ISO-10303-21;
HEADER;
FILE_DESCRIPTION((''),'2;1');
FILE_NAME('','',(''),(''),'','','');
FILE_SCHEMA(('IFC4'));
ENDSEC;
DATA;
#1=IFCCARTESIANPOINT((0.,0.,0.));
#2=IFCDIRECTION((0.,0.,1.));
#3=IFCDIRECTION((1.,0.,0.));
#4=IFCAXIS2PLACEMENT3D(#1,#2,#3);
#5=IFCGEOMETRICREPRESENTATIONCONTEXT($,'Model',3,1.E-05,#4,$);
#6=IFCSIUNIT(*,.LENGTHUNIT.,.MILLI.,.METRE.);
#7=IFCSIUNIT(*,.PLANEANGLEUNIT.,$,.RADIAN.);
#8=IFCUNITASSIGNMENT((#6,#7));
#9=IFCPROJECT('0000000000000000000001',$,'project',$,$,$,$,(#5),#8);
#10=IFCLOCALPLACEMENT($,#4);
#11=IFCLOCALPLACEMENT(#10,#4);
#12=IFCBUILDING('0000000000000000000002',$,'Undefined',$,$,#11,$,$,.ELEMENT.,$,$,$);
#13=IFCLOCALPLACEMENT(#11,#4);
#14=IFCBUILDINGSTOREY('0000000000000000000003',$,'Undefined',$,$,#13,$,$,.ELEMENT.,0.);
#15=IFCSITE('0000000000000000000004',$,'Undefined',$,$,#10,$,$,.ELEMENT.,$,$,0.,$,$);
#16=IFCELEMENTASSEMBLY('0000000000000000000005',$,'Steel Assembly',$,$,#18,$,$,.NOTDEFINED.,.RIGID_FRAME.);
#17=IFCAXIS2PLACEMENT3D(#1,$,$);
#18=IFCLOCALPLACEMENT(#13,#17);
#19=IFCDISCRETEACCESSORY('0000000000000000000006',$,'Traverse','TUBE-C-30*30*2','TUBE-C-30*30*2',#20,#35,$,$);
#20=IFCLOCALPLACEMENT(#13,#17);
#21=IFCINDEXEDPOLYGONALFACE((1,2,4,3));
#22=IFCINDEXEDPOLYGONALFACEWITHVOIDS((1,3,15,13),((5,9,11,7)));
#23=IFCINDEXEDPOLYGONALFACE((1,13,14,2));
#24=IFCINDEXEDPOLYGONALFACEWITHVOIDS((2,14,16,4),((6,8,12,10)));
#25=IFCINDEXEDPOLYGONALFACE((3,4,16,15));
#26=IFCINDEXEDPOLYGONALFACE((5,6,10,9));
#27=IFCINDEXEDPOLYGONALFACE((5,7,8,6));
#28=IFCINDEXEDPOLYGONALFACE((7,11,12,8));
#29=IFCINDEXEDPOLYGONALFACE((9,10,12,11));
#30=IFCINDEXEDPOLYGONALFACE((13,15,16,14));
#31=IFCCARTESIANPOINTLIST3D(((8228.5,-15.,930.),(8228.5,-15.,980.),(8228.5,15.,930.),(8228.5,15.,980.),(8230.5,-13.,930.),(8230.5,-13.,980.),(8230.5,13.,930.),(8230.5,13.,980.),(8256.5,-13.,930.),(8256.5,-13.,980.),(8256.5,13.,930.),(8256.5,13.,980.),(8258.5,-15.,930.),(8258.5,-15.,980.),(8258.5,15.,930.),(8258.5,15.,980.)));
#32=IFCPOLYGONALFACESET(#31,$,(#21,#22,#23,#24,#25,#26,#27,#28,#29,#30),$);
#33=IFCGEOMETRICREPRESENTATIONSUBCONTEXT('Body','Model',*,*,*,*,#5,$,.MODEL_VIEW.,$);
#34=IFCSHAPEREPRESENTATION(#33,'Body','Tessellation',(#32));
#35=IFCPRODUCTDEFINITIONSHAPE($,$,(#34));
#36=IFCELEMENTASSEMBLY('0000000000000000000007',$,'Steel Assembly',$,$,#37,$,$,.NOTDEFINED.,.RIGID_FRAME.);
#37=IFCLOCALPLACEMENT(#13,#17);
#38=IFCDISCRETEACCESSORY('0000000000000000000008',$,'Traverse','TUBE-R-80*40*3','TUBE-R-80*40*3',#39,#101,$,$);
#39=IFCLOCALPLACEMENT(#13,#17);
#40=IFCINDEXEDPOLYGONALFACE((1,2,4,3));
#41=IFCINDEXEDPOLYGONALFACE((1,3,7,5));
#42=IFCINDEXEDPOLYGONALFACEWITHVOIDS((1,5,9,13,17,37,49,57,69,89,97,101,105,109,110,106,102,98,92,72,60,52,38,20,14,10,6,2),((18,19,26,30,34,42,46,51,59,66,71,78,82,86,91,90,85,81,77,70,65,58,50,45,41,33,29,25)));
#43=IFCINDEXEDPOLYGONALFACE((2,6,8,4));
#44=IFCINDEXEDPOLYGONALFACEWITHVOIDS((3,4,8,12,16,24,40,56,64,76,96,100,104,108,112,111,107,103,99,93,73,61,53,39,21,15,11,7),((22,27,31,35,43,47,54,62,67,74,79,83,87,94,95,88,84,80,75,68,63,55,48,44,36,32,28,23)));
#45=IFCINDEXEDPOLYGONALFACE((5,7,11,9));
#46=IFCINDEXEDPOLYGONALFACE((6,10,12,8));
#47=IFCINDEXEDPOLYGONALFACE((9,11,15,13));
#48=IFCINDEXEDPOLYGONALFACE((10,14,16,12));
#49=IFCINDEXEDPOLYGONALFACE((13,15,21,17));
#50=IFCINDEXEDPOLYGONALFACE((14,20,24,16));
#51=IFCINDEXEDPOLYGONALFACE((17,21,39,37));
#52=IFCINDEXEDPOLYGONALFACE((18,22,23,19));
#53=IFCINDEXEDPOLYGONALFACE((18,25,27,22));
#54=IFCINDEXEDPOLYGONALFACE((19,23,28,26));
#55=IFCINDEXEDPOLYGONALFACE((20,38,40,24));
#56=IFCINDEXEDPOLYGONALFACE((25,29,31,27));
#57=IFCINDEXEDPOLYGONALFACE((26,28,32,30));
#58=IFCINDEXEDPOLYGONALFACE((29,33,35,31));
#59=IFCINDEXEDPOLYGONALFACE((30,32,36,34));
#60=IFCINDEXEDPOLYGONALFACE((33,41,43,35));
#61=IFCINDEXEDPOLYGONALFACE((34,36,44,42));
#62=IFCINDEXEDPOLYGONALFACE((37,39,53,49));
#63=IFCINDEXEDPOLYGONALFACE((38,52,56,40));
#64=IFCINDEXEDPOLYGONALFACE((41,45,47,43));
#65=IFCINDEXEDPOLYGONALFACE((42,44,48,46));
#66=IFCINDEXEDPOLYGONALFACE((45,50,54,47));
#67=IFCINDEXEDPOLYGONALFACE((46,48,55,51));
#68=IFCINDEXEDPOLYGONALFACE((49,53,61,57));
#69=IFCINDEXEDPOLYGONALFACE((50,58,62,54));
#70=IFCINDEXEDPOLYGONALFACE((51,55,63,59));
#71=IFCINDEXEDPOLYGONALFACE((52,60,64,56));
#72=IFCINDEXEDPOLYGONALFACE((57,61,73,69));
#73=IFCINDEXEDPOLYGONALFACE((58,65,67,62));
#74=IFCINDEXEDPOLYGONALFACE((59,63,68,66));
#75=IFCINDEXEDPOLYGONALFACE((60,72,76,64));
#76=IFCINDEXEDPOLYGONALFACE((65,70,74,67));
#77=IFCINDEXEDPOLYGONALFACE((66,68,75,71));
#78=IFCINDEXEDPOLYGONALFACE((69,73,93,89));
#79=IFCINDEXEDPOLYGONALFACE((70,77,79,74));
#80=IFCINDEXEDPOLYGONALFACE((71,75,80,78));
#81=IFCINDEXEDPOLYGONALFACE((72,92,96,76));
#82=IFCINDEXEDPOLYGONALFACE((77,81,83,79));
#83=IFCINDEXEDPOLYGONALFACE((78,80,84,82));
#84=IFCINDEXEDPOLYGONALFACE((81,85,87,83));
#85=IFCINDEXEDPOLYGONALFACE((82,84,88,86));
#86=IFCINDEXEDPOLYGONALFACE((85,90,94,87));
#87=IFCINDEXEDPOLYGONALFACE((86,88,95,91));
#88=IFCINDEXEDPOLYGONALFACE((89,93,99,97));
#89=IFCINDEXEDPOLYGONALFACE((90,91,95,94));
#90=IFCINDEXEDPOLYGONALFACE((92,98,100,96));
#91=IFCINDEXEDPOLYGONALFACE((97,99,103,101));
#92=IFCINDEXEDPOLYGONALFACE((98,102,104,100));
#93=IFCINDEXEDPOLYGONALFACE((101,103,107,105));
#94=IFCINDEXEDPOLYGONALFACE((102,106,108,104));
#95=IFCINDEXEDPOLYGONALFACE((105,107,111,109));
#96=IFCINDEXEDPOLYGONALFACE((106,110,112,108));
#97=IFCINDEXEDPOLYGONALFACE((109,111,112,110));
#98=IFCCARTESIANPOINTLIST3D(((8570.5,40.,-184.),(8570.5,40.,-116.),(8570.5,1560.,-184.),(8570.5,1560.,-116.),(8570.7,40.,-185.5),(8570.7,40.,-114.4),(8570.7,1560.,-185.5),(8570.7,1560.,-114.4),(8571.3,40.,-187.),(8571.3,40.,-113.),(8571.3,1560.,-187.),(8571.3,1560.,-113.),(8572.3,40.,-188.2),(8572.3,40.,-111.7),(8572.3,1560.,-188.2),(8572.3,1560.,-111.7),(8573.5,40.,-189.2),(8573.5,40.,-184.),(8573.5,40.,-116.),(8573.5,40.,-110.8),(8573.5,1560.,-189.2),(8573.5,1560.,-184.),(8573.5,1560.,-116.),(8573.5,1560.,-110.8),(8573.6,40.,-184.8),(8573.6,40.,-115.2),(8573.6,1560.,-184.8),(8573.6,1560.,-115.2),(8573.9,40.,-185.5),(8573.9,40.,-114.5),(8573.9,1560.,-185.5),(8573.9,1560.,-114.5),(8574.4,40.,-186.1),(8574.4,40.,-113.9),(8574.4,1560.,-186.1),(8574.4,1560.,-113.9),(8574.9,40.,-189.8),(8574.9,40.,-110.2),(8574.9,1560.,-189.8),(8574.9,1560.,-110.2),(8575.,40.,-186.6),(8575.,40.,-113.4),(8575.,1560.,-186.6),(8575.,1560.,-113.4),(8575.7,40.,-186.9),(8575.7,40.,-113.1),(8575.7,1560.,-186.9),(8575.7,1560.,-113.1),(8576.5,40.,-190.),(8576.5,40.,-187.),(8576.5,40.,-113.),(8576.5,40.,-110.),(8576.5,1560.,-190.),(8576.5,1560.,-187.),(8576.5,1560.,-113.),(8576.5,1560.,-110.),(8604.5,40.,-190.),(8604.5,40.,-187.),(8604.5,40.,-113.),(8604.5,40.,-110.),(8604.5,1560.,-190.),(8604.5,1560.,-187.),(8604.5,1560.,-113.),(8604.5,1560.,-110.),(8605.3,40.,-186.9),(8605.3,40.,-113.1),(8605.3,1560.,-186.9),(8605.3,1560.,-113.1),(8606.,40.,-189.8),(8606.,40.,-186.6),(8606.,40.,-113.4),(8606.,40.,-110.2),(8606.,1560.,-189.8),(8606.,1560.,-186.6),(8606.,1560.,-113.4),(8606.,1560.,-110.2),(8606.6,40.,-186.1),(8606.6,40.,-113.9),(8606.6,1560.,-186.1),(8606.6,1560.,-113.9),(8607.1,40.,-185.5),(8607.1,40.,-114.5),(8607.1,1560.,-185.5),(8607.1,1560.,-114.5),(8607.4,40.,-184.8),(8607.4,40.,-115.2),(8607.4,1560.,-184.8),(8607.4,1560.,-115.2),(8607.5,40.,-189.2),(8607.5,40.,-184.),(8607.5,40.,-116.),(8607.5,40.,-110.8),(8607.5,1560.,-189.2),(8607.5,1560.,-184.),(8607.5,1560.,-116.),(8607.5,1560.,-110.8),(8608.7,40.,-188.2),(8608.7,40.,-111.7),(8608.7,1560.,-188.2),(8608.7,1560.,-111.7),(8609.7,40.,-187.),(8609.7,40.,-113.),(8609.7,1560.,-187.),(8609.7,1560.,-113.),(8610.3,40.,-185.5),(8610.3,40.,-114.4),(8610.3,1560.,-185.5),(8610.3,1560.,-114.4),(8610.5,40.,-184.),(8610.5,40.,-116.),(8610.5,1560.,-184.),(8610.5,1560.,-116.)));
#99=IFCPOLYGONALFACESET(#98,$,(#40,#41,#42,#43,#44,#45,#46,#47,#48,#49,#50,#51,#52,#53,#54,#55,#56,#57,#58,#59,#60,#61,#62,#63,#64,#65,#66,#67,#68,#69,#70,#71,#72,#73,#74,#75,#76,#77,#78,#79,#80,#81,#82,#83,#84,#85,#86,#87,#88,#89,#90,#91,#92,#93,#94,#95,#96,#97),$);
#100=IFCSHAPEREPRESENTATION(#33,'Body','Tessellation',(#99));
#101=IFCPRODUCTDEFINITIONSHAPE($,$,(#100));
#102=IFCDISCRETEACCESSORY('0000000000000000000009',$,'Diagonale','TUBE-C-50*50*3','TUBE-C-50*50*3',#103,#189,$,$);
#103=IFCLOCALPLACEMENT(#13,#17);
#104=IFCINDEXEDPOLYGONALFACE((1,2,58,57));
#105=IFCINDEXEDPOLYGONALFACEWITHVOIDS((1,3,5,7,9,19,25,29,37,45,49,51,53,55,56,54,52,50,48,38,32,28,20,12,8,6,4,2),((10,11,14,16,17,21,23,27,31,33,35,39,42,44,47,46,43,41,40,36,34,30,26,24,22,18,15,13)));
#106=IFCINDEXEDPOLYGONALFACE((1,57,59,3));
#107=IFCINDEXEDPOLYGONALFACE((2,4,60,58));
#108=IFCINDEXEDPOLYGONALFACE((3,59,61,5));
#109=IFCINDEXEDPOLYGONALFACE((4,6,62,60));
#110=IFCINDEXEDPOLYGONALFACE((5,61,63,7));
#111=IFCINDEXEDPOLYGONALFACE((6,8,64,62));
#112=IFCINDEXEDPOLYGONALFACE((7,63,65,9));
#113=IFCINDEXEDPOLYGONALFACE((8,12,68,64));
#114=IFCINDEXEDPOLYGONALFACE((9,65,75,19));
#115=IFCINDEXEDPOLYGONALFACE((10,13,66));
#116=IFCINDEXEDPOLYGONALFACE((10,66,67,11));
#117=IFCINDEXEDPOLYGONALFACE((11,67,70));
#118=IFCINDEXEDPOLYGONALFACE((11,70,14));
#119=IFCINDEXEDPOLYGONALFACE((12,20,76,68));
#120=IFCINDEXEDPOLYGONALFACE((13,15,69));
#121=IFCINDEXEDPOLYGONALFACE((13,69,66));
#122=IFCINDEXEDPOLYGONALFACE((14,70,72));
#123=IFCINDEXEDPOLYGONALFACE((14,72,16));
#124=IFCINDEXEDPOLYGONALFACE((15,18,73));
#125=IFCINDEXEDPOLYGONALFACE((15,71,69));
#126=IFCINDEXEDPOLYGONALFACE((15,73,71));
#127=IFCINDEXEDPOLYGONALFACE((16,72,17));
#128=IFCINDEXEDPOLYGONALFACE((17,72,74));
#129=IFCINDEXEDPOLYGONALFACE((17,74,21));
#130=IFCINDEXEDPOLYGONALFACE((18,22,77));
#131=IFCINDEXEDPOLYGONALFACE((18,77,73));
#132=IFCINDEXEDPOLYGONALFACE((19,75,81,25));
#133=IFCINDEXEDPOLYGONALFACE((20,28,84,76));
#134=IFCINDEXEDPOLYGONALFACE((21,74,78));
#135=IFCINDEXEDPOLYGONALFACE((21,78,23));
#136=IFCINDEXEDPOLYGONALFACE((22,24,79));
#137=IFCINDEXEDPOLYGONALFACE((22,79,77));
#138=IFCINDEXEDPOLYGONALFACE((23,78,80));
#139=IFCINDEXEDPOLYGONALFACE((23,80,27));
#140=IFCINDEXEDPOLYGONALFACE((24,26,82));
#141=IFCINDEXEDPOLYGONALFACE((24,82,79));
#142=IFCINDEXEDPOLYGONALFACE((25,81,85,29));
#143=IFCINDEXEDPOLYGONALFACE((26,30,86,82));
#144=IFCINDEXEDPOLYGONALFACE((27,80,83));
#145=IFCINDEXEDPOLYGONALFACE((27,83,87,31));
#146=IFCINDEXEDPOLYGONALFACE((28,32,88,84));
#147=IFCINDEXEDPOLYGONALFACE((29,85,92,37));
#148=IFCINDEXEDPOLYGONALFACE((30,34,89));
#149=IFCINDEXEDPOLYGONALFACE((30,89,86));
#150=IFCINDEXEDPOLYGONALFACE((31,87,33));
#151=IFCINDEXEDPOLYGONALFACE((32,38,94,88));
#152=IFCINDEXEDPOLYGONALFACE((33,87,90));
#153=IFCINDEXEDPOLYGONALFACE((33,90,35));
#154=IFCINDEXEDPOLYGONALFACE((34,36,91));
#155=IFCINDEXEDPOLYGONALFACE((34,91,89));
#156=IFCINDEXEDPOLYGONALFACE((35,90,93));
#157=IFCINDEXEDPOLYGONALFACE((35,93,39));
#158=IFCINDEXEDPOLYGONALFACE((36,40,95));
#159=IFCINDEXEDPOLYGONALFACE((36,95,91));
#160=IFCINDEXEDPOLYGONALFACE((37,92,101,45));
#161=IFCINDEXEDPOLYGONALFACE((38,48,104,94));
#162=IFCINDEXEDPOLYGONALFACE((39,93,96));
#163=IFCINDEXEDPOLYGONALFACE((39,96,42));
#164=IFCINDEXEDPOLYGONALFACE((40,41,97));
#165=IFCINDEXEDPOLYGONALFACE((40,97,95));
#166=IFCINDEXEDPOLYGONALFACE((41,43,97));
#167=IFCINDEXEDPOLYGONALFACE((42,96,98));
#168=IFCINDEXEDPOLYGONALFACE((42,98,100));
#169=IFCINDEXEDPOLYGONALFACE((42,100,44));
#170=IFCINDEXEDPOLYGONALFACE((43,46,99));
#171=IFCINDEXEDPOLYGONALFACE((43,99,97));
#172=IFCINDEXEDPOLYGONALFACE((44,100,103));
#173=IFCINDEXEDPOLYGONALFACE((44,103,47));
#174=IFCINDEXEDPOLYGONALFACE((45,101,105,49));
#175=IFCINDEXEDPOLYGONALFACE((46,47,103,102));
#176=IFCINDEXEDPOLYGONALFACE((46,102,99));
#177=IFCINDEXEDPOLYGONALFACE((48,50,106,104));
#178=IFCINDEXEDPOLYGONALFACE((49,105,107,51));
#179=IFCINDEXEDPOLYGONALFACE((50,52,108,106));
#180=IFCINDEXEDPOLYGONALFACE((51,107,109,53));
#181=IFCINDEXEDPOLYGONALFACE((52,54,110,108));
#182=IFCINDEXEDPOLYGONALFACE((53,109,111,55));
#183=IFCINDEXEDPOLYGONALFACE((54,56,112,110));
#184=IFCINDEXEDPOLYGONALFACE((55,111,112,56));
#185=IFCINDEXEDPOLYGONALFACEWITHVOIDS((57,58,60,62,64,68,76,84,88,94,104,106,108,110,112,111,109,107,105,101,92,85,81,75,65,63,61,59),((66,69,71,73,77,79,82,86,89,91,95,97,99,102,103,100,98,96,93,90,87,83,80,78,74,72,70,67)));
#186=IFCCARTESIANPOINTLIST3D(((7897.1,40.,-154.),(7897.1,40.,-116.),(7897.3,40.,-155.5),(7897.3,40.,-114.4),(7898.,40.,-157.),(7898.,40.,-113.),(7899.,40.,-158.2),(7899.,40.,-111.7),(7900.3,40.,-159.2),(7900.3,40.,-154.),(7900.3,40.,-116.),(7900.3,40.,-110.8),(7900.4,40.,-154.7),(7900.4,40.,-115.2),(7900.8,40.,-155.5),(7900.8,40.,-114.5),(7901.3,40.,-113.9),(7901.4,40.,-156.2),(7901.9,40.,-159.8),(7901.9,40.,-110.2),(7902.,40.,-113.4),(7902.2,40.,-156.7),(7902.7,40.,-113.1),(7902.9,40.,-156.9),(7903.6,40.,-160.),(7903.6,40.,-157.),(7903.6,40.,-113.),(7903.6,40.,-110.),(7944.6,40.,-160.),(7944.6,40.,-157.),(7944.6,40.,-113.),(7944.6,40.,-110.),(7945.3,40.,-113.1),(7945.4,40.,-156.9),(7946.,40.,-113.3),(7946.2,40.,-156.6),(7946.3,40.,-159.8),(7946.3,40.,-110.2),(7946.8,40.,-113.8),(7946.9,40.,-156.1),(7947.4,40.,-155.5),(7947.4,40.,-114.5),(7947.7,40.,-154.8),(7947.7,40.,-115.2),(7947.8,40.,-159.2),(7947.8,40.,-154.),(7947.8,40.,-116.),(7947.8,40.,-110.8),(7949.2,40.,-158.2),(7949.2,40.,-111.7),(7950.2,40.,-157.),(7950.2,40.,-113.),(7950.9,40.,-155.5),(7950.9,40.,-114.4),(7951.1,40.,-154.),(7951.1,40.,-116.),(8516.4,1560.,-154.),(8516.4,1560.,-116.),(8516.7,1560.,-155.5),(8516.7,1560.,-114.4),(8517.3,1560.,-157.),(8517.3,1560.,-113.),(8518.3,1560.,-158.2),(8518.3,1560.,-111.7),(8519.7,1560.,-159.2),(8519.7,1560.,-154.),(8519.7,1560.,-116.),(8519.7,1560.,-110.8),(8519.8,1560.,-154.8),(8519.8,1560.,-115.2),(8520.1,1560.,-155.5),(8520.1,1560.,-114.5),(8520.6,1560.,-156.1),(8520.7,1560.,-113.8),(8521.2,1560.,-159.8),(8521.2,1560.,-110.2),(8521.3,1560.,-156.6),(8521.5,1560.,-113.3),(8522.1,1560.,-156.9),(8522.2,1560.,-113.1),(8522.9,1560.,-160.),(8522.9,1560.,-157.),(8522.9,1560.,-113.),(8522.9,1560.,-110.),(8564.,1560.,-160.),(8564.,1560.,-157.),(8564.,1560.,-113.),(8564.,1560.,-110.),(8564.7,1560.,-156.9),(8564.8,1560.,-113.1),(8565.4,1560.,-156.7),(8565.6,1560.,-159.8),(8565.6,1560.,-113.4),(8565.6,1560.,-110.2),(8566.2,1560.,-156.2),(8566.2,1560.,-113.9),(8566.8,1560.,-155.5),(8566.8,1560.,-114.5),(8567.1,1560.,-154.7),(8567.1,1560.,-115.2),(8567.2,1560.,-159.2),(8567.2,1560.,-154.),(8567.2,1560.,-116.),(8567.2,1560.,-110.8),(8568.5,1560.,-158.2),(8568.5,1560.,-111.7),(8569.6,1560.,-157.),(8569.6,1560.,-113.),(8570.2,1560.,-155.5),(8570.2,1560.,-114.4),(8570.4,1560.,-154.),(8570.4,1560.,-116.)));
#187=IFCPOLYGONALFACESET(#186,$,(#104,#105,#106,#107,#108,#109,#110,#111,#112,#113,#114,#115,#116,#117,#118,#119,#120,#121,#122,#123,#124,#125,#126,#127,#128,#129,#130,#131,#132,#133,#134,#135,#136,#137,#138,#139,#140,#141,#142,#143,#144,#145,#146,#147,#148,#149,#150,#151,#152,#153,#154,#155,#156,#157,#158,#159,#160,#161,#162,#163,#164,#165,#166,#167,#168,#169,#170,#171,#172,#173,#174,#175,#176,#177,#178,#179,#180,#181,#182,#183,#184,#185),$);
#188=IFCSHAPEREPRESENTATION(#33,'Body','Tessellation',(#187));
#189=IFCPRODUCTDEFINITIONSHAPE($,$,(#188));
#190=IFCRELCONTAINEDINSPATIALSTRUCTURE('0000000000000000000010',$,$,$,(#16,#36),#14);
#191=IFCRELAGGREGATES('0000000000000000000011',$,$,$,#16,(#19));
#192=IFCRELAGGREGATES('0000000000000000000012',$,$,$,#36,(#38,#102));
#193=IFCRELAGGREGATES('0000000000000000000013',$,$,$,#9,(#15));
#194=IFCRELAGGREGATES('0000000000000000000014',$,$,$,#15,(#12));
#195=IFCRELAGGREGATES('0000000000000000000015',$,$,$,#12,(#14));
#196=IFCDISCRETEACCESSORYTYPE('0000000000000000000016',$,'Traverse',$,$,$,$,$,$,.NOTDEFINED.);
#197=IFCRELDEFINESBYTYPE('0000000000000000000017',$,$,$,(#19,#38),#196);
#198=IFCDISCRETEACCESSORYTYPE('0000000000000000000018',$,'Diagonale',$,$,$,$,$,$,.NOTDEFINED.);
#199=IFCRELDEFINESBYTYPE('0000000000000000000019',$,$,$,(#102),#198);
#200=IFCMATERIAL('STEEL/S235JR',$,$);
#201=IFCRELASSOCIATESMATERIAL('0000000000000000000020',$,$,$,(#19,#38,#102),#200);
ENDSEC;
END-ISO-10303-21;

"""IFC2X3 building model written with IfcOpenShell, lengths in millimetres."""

from ifc_helpers import new_model, si_unit, frame, origin_with_axes, origin_2d_with_axis, place, context, subcontext, project, spatial, hollow_rectangle, extrude, clip, halfspace, material, type_object, element, aggregate, save


model = new_model("IFC2X3")

# Units and contexts
model_context = context("Model", 3, precision=1e-05, world=origin_with_axes())
body_context = subcontext(model_context, "Body", "Model", "MODEL_VIEW")
ifc_project = project(units=[si_unit("LENGTHUNIT", "METRE", prefix="MILLI"), si_unit("PLANEANGLEUNIT", "RADIAN")], contexts=[model_context])

# Site, building, storey
site_placement = place(None, origin_with_axes())
site = spatial("IfcSite", under=ifc_project, at=site_placement, Name="Undefined", CompositionType="ELEMENT", RefElevation=0.0)
building_placement = place(site_placement, origin_with_axes())
building = spatial("IfcBuilding", under=site, at=building_placement, Name="Undefined", CompositionType="ELEMENT")
storey_placement = place(building_placement, origin_with_axes())
storey = spatial("IfcBuildingStorey", under=building, at=storey_placement, Name="Undefined", CompositionType="ELEMENT", Elevation=0.0)

# Shared definitions
ifc_material = material(Name="STEEL/S235JR")

# Element assembly
assembly_1_placement = place(storey_placement, origin_with_axes())
assembly_1 = element("IfcElementAssembly", 1, at=assembly_1_placement, inside=storey, Name="Steel Assembly", AssemblyPlace="NOTDEFINED", PredefinedType="RIGID_FRAME")

# Discrete accessory
discrete_accessory_type_1 = type_object("IfcDiscreteAccessoryType", Name="Traverse")
discrete_accessory_1_placement = place(assembly_1_placement, frame((8243.5, 0.0, 930.0), z_axis=(0.0, 0.0, 1.0), x_axis=(1.0, 0.0, 0.0)))
discrete_accessory_1 = element("IfcDiscreteAccessory", 2, at=discrete_accessory_1_placement, type_object=discrete_accessory_type_1, material=ifc_material, Name="Traverse", Description="TUBE-C-30*30*2", ObjectType="TUBE-C-30*30*2", context=body_context, shape_type="SweptSolid", body=[
    extrude(hollow_rectangle(XDim=30.0, YDim=30.0, WallThickness=2.0, at=origin_2d_with_axis()), frame((0.0, 0.0, 50.0), z_axis=(0.0, 0.0, -1.0), x_axis=(-1.0, 0.0, 0.0)), (0.0, 0.0, 1.0), 50.0),
])
aggregate(assembly_1, [discrete_accessory_1])

# Element assembly, discrete accessory
assembly_2_placement = place(storey_placement, origin_with_axes())
assembly_2 = element("IfcElementAssembly", 3, at=assembly_2_placement, inside=storey, Name="Steel Assembly", AssemblyPlace="NOTDEFINED", PredefinedType="RIGID_FRAME")
discrete_accessory_2_placement = place(assembly_2_placement, frame((8590.5, 1560.0, -150.0), z_axis=(0.0, 0.0, 1.0), x_axis=(0.0, -1.0, 0.0)))
discrete_accessory_2 = element("IfcDiscreteAccessory", 4, at=discrete_accessory_2_placement, type_object=discrete_accessory_type_1, material=ifc_material, Name="Traverse", Description="TUBE-R-80*40*3", ObjectType="TUBE-R-80*40*3", context=body_context, shape_type="SweptSolid", body=[
    extrude(hollow_rectangle(XDim=40.0, YDim=80.0, WallThickness=3.0, InnerFilletRadius=3.0, OuterFilletRadius=6.0, at=origin_2d_with_axis()), frame((1520.0, 0.0, 0.0), z_axis=(-1.0, 0.0, 0.0), x_axis=(0.0, -1.0, 0.0)), (0.0, 0.0, 1.0), 1520.0),
])

# Discrete accessory
discrete_accessory_type_2 = type_object("IfcDiscreteAccessoryType", Name="Diagonale")
discrete_accessory_3_placement = place(assembly_2_placement, frame((8551.2, 1579.1, -135.0), z_axis=(-0.926073, 0.377344, 0.0), x_axis=(-0.377344, -0.926073, 0.0)))
discrete_accessory_3 = element("IfcDiscreteAccessory", 5, at=discrete_accessory_3_placement, type_object=discrete_accessory_type_2, material=ifc_material, Name="Diagonale", Description="TUBE-C-50*50*3", ObjectType="TUBE-C-50*50*3", context=body_context, shape_type="Clipping", body=[
    clip(clip(extrude(hollow_rectangle(XDim=50.0, YDim=50.0, WallThickness=3.0, InnerFilletRadius=3.0, OuterFilletRadius=6.0, at=origin_2d_with_axis()), frame((1682.5, 0.0, 0.0), z_axis=(-1.0, 0.0, 0.0), x_axis=(0.0, -1.0, 0.0)), (0.0, 0.0, 1.0), 1682.5), halfspace(frame((10.4, 25.0, -25.0), z_axis=(-0.926073, 0.0, 0.377344), x_axis=(0.377344, 0.0, 0.926073)), False)), halfspace(frame((1651.7, -25.0, -25.0), z_axis=(0.926073, 0.0, -0.377344), x_axis=(0.377344, 0.0, 0.926073)), False)),
])
aggregate(assembly_2, [discrete_accessory_2, discrete_accessory_3])

save(model, "model.ifc")
